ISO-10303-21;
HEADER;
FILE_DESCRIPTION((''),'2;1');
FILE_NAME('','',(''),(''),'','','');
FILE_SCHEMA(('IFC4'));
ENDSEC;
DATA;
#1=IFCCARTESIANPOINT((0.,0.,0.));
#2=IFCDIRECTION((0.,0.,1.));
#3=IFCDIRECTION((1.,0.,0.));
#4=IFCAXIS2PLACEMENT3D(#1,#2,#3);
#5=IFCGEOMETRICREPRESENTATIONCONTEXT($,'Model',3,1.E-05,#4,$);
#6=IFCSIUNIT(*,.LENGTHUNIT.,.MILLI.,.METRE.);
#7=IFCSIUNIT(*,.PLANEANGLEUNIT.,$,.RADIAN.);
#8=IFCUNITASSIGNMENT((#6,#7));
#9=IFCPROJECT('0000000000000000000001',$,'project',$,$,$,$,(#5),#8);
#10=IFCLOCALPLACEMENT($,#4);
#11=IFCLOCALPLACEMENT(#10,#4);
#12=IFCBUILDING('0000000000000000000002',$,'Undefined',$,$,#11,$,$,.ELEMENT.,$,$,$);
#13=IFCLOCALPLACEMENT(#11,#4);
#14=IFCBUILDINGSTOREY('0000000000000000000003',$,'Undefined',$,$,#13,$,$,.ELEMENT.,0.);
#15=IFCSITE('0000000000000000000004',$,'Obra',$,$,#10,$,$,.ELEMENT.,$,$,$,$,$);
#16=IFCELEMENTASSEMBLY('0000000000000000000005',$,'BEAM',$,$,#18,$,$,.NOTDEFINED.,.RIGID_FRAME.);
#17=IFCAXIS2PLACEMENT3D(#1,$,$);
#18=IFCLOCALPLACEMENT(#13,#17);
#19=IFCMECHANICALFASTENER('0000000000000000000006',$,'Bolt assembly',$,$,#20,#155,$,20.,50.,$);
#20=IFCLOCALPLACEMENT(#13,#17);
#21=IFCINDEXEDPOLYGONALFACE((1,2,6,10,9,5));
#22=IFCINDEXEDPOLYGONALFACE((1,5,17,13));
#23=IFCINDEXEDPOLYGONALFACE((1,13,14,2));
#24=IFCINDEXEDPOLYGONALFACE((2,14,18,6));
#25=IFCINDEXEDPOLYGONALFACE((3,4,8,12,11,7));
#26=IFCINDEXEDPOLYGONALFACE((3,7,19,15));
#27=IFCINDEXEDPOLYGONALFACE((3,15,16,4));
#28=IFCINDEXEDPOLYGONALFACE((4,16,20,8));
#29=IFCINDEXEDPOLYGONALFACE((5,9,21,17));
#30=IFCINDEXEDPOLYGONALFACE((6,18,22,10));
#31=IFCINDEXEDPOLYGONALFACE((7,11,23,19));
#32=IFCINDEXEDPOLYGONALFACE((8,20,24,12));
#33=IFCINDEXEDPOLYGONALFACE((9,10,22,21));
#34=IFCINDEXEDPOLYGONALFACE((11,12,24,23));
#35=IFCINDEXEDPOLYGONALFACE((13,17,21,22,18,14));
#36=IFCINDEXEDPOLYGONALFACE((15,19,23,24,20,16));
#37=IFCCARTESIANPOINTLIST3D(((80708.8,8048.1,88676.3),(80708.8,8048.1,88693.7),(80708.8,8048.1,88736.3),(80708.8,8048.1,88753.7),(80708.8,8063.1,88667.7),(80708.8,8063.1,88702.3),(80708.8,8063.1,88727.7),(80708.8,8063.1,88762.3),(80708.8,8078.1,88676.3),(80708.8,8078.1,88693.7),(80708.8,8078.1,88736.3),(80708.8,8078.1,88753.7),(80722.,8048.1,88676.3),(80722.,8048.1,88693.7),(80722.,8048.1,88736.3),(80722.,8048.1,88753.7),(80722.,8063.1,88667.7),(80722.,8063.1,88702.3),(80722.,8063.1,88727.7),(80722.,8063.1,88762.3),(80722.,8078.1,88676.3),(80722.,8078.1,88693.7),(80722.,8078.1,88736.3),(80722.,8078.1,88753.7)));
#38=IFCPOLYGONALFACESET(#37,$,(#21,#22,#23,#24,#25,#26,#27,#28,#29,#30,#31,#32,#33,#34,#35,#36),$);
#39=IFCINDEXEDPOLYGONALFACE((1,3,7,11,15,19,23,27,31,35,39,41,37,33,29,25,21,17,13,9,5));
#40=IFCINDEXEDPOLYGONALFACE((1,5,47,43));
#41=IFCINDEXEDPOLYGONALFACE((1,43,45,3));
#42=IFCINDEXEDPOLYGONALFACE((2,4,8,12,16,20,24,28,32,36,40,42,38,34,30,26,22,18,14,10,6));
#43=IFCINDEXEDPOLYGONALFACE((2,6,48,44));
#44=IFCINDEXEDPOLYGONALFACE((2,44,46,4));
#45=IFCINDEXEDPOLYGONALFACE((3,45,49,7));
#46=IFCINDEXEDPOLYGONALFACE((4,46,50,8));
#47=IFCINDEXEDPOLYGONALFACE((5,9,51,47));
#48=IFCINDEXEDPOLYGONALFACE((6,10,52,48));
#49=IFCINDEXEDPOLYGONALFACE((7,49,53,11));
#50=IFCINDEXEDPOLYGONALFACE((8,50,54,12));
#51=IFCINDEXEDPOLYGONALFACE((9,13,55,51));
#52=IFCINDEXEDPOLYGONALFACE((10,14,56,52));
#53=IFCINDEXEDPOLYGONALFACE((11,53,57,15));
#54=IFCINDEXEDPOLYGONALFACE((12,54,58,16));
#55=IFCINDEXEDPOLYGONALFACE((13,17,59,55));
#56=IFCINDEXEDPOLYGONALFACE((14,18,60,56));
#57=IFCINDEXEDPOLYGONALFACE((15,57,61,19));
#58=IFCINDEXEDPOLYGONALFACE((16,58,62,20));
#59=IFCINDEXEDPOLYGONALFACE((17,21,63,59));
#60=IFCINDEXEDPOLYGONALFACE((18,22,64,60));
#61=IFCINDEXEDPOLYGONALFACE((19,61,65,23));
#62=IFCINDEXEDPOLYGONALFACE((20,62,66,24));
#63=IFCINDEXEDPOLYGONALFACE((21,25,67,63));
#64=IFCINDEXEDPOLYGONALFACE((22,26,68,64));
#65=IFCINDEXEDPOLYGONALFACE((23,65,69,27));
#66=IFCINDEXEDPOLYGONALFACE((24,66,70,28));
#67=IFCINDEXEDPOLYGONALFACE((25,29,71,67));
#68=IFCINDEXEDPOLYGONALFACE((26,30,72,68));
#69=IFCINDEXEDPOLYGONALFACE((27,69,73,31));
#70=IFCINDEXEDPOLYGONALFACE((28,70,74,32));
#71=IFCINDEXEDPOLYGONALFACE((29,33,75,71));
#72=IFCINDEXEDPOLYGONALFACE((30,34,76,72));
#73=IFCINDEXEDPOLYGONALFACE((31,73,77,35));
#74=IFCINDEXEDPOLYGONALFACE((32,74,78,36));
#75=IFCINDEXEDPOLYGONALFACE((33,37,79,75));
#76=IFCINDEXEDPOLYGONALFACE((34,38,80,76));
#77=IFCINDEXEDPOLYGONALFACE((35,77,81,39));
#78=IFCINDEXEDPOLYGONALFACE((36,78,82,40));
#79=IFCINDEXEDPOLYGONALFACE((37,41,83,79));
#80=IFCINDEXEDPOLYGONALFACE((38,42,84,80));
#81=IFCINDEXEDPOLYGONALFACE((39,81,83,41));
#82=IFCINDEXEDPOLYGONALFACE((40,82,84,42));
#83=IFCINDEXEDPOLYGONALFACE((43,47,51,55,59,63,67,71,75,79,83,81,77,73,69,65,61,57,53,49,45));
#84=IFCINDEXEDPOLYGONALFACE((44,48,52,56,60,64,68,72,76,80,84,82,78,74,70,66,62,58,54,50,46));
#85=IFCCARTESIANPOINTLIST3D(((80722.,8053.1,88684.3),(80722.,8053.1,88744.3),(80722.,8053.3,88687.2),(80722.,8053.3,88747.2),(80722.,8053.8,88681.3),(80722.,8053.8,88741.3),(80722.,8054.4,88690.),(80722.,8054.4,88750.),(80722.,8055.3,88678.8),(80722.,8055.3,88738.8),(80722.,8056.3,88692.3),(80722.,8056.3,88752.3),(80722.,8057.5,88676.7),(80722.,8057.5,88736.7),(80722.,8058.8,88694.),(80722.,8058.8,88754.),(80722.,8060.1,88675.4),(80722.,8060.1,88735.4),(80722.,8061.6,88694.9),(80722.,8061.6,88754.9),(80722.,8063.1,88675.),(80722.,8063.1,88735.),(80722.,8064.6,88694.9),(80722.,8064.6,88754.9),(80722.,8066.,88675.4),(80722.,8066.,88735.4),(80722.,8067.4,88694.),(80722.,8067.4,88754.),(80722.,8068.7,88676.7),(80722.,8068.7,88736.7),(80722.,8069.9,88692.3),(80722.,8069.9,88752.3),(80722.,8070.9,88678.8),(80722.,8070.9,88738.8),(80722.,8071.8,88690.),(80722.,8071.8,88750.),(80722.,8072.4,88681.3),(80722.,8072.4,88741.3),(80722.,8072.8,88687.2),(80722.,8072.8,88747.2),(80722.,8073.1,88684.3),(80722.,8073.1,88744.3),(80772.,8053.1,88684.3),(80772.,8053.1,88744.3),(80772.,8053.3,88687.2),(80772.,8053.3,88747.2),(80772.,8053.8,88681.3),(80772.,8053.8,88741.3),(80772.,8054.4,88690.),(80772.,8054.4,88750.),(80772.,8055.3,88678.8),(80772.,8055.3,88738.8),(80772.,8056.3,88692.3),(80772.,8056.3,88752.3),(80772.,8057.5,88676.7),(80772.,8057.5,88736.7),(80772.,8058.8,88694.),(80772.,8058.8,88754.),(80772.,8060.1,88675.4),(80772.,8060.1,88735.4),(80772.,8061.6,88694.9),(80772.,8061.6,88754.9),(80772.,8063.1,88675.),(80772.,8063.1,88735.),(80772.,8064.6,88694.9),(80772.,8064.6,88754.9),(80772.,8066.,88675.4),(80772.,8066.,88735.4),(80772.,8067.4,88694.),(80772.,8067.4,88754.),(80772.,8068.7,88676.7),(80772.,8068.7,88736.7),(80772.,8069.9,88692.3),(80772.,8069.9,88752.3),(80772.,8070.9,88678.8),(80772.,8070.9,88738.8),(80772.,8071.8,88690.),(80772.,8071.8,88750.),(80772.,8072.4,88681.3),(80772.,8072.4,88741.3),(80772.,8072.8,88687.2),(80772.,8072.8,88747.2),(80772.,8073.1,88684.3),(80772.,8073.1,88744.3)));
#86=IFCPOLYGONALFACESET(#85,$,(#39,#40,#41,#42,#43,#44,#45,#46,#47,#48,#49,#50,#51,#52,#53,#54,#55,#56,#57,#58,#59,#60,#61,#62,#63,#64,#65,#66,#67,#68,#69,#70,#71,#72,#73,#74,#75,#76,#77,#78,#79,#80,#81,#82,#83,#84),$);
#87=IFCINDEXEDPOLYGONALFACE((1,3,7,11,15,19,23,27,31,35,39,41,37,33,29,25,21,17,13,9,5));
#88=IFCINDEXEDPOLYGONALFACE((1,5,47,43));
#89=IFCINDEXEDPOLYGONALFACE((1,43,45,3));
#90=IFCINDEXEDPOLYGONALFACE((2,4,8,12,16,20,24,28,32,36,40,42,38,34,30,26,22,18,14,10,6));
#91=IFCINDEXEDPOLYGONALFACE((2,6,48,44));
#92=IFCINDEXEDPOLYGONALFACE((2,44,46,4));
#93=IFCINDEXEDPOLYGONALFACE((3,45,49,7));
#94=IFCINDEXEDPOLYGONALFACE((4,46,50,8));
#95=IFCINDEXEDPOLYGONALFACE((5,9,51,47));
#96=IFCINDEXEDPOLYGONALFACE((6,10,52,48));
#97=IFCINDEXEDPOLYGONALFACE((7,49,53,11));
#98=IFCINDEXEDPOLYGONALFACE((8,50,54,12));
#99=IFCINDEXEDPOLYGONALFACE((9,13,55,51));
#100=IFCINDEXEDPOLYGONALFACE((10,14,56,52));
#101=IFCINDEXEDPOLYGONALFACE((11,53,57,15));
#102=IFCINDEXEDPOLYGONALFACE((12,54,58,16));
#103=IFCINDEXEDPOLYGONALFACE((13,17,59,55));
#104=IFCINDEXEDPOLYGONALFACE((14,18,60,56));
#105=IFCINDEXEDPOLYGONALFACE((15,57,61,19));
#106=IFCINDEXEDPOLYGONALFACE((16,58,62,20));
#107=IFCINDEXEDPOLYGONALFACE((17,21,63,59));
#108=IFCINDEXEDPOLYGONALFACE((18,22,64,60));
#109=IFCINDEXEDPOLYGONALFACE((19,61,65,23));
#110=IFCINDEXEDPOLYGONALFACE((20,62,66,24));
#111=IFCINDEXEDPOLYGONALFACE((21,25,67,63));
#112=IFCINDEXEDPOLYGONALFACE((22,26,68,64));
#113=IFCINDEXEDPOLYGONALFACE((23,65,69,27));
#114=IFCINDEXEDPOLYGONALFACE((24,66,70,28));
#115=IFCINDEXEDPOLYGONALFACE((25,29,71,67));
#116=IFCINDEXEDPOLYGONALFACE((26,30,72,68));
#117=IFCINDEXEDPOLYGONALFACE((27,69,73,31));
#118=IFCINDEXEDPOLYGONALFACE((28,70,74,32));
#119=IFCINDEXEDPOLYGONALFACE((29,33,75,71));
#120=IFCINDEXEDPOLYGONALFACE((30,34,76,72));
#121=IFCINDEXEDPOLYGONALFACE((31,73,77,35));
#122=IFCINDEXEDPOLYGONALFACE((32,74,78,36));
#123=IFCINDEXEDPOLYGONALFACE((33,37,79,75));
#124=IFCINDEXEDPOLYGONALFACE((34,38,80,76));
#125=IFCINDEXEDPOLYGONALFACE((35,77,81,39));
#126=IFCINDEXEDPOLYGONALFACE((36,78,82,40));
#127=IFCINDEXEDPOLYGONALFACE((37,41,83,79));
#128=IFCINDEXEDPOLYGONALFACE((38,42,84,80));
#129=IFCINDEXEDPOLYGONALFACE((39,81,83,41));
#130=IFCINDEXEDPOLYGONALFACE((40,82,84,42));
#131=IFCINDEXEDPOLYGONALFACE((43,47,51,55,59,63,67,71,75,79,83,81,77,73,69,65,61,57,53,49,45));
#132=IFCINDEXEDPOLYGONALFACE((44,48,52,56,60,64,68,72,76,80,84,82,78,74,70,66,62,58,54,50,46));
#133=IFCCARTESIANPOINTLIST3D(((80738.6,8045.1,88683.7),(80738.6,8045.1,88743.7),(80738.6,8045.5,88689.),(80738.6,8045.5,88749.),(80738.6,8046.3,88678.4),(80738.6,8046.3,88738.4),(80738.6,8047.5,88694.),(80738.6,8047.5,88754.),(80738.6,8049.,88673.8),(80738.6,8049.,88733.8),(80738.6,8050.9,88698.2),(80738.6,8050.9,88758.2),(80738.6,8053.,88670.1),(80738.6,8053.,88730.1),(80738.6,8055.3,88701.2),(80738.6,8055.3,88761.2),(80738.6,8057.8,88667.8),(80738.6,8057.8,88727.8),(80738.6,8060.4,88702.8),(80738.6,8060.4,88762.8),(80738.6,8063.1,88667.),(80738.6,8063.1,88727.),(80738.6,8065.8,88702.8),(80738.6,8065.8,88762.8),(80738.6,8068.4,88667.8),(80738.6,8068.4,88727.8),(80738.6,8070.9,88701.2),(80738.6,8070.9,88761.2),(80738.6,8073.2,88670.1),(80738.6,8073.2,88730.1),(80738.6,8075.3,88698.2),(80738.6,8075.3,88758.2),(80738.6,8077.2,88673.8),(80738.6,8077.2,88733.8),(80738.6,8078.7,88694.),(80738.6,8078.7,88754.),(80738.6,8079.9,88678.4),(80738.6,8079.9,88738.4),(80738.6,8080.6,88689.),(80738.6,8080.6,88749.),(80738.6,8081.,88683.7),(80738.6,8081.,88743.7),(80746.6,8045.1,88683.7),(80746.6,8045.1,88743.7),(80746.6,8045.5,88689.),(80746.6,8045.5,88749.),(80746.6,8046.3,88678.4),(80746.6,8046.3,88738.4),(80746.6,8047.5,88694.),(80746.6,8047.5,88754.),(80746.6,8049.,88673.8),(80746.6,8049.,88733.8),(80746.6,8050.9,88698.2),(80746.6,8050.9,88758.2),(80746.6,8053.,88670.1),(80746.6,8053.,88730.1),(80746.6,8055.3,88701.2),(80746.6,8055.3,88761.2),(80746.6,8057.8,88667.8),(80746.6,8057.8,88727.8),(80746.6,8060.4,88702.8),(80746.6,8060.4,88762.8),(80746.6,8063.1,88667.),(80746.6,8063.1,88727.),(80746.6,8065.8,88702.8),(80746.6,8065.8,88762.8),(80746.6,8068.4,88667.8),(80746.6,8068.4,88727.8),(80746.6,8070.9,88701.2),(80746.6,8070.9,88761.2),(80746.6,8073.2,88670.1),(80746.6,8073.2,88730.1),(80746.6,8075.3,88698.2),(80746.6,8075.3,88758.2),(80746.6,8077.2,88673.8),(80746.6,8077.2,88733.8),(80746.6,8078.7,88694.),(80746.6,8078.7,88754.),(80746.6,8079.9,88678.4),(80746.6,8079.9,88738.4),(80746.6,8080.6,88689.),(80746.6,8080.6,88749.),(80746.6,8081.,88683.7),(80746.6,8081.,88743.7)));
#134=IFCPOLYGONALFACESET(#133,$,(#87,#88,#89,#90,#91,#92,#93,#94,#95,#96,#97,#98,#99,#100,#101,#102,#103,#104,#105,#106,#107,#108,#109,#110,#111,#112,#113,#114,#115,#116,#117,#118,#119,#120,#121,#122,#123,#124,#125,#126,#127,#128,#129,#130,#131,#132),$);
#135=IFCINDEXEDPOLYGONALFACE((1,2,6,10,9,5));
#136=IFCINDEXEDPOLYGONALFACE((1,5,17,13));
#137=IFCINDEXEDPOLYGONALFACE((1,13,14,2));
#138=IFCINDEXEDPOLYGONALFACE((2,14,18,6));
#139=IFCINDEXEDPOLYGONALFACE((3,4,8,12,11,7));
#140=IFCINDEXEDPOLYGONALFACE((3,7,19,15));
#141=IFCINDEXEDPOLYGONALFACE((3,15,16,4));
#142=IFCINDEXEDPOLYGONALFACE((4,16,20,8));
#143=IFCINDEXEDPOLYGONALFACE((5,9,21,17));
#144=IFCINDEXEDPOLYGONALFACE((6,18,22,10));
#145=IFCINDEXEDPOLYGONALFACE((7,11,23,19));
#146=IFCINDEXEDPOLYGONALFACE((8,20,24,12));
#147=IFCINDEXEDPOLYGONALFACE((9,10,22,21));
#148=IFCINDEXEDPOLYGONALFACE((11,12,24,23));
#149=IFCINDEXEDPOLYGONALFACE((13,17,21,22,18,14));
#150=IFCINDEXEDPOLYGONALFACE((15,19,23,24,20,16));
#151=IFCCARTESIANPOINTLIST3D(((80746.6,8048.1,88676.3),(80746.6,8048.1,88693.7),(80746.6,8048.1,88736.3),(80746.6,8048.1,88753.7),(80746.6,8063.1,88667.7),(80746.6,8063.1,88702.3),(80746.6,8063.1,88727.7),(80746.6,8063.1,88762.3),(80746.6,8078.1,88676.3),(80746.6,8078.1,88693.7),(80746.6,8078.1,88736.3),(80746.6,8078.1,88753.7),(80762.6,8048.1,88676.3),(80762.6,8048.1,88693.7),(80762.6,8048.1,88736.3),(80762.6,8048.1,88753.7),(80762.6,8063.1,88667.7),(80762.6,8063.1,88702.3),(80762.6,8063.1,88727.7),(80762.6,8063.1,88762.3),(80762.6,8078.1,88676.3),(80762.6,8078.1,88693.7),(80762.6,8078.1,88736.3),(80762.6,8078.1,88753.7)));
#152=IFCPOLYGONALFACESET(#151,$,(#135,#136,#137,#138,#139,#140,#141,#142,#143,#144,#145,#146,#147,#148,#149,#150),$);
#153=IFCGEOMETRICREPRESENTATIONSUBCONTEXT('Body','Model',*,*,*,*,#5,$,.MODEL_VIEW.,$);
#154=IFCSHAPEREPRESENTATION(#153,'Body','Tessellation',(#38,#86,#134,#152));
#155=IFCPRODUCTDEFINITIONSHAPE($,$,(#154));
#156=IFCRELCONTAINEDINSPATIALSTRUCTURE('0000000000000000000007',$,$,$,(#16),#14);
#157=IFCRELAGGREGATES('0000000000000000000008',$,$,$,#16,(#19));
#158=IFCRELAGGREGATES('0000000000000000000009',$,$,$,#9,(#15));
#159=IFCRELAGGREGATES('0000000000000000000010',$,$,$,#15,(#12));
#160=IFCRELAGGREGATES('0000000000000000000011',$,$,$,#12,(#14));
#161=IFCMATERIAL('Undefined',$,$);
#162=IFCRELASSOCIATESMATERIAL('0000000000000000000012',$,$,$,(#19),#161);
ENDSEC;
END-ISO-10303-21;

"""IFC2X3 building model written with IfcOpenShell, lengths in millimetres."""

from ifc_helpers import new_model, si_unit, frame, origin_with_axes, origin_2d_with_axis, place, context, subcontext, project, spatial, polyline, circle, outline, extrude, source, transform, mapped, material, element, aggregate, save


model = new_model("IFC2X3")

# Units and contexts
model_context = context("Model", 3, precision=1e-05, world=origin_with_axes())
body_context = subcontext(model_context, "Body", "Model", "MODEL_VIEW")
ifc_project = project(units=[si_unit("LENGTHUNIT", "METRE", prefix="MILLI"), si_unit("PLANEANGLEUNIT", "RADIAN")], contexts=[model_context])

# Site, building, storey
site_placement = place(None, origin_with_axes())
site = spatial("IfcSite", under=ifc_project, at=site_placement, Name="Obra", CompositionType="ELEMENT")
building_placement = place(site_placement, origin_with_axes())
building = spatial("IfcBuilding", under=site, at=building_placement, Name="Undefined", CompositionType="ELEMENT")
storey_placement = place(building_placement, origin_with_axes())
storey = spatial("IfcBuildingStorey", under=building, at=storey_placement, Name="Undefined", CompositionType="ELEMENT", Elevation=0.0)

# Shared definitions
ifc_material_1 = material(Name="Undefined")

# Element assembly, mechanical fastener
shared_shape_1 = source(origin_with_axes(), body_context, "Body", "SweptSolid", [
    extrude(outline(polyline([(17.3, 0.0), (8.7, 15.0), (-8.7, 15.0), (-17.3, 0.0), (-8.7, -15.0), (8.7, -15.0), (17.3, 0.0)])), frame((0.0, -26.5, 0.0), z_axis=(0.0, 1.0, 0.0), x_axis=(1.0, 0.0, 0.0)), (0.0, 0.0, 1.0), 13.2),
    extrude(circle(Radius=10.0, at=origin_2d_with_axis()), frame((0.0, -13.3, 0.0), z_axis=(0.0, 1.0, 0.0), x_axis=(1.0, 0.0, 0.0)), (0.0, 0.0, 1.0), 50.0),
    extrude(circle(Radius=18.0, at=origin_2d_with_axis()), frame((0.0, 3.3, 0.0), z_axis=(0.0, 1.0, 0.0), x_axis=(1.0, 0.0, 0.0)), (0.0, 0.0, 1.0), 8.0),
    extrude(outline(polyline([(17.3, 0.0), (8.7, 15.0), (-8.7, 15.0), (-17.3, 0.0), (-8.7, -15.0), (8.7, -15.0), (17.3, 0.0)])), frame((0.0, 11.3, 0.0), z_axis=(0.0, 1.0, 0.0), x_axis=(1.0, 0.0, 0.0)), (0.0, 0.0, 1.0), 16.0),
])
assembly_1_placement = place(storey_placement, origin_with_axes())
assembly_1 = element("IfcElementAssembly", 1, at=assembly_1_placement, inside=storey, Name="BEAM", AssemblyPlace="NOTDEFINED", PredefinedType="RIGID_FRAME")
mechanical_fastener_1_placement = place(assembly_1_placement, frame((80735.3, 8103.1, 88850.0), z_axis=(0.0, -1.0, 0.0), x_axis=(0.0, 0.0, -1.0)))
mechanical_fastener_1 = element("IfcMechanicalFastener", 2, at=mechanical_fastener_1_placement, material=ifc_material_1, Name="Bolt assembly", NominalDiameter=20.0, NominalLength=50.0, context=body_context, shape_type="MappedRepresentation", body=[
    mapped(shared_shape_1, transform((105.0, 0.0, 40.0))),
    mapped(shared_shape_1, transform((165.0, 0.0, 40.0))),
])
aggregate(assembly_1, [mechanical_fastener_1])

save(model, "model.ifc")
